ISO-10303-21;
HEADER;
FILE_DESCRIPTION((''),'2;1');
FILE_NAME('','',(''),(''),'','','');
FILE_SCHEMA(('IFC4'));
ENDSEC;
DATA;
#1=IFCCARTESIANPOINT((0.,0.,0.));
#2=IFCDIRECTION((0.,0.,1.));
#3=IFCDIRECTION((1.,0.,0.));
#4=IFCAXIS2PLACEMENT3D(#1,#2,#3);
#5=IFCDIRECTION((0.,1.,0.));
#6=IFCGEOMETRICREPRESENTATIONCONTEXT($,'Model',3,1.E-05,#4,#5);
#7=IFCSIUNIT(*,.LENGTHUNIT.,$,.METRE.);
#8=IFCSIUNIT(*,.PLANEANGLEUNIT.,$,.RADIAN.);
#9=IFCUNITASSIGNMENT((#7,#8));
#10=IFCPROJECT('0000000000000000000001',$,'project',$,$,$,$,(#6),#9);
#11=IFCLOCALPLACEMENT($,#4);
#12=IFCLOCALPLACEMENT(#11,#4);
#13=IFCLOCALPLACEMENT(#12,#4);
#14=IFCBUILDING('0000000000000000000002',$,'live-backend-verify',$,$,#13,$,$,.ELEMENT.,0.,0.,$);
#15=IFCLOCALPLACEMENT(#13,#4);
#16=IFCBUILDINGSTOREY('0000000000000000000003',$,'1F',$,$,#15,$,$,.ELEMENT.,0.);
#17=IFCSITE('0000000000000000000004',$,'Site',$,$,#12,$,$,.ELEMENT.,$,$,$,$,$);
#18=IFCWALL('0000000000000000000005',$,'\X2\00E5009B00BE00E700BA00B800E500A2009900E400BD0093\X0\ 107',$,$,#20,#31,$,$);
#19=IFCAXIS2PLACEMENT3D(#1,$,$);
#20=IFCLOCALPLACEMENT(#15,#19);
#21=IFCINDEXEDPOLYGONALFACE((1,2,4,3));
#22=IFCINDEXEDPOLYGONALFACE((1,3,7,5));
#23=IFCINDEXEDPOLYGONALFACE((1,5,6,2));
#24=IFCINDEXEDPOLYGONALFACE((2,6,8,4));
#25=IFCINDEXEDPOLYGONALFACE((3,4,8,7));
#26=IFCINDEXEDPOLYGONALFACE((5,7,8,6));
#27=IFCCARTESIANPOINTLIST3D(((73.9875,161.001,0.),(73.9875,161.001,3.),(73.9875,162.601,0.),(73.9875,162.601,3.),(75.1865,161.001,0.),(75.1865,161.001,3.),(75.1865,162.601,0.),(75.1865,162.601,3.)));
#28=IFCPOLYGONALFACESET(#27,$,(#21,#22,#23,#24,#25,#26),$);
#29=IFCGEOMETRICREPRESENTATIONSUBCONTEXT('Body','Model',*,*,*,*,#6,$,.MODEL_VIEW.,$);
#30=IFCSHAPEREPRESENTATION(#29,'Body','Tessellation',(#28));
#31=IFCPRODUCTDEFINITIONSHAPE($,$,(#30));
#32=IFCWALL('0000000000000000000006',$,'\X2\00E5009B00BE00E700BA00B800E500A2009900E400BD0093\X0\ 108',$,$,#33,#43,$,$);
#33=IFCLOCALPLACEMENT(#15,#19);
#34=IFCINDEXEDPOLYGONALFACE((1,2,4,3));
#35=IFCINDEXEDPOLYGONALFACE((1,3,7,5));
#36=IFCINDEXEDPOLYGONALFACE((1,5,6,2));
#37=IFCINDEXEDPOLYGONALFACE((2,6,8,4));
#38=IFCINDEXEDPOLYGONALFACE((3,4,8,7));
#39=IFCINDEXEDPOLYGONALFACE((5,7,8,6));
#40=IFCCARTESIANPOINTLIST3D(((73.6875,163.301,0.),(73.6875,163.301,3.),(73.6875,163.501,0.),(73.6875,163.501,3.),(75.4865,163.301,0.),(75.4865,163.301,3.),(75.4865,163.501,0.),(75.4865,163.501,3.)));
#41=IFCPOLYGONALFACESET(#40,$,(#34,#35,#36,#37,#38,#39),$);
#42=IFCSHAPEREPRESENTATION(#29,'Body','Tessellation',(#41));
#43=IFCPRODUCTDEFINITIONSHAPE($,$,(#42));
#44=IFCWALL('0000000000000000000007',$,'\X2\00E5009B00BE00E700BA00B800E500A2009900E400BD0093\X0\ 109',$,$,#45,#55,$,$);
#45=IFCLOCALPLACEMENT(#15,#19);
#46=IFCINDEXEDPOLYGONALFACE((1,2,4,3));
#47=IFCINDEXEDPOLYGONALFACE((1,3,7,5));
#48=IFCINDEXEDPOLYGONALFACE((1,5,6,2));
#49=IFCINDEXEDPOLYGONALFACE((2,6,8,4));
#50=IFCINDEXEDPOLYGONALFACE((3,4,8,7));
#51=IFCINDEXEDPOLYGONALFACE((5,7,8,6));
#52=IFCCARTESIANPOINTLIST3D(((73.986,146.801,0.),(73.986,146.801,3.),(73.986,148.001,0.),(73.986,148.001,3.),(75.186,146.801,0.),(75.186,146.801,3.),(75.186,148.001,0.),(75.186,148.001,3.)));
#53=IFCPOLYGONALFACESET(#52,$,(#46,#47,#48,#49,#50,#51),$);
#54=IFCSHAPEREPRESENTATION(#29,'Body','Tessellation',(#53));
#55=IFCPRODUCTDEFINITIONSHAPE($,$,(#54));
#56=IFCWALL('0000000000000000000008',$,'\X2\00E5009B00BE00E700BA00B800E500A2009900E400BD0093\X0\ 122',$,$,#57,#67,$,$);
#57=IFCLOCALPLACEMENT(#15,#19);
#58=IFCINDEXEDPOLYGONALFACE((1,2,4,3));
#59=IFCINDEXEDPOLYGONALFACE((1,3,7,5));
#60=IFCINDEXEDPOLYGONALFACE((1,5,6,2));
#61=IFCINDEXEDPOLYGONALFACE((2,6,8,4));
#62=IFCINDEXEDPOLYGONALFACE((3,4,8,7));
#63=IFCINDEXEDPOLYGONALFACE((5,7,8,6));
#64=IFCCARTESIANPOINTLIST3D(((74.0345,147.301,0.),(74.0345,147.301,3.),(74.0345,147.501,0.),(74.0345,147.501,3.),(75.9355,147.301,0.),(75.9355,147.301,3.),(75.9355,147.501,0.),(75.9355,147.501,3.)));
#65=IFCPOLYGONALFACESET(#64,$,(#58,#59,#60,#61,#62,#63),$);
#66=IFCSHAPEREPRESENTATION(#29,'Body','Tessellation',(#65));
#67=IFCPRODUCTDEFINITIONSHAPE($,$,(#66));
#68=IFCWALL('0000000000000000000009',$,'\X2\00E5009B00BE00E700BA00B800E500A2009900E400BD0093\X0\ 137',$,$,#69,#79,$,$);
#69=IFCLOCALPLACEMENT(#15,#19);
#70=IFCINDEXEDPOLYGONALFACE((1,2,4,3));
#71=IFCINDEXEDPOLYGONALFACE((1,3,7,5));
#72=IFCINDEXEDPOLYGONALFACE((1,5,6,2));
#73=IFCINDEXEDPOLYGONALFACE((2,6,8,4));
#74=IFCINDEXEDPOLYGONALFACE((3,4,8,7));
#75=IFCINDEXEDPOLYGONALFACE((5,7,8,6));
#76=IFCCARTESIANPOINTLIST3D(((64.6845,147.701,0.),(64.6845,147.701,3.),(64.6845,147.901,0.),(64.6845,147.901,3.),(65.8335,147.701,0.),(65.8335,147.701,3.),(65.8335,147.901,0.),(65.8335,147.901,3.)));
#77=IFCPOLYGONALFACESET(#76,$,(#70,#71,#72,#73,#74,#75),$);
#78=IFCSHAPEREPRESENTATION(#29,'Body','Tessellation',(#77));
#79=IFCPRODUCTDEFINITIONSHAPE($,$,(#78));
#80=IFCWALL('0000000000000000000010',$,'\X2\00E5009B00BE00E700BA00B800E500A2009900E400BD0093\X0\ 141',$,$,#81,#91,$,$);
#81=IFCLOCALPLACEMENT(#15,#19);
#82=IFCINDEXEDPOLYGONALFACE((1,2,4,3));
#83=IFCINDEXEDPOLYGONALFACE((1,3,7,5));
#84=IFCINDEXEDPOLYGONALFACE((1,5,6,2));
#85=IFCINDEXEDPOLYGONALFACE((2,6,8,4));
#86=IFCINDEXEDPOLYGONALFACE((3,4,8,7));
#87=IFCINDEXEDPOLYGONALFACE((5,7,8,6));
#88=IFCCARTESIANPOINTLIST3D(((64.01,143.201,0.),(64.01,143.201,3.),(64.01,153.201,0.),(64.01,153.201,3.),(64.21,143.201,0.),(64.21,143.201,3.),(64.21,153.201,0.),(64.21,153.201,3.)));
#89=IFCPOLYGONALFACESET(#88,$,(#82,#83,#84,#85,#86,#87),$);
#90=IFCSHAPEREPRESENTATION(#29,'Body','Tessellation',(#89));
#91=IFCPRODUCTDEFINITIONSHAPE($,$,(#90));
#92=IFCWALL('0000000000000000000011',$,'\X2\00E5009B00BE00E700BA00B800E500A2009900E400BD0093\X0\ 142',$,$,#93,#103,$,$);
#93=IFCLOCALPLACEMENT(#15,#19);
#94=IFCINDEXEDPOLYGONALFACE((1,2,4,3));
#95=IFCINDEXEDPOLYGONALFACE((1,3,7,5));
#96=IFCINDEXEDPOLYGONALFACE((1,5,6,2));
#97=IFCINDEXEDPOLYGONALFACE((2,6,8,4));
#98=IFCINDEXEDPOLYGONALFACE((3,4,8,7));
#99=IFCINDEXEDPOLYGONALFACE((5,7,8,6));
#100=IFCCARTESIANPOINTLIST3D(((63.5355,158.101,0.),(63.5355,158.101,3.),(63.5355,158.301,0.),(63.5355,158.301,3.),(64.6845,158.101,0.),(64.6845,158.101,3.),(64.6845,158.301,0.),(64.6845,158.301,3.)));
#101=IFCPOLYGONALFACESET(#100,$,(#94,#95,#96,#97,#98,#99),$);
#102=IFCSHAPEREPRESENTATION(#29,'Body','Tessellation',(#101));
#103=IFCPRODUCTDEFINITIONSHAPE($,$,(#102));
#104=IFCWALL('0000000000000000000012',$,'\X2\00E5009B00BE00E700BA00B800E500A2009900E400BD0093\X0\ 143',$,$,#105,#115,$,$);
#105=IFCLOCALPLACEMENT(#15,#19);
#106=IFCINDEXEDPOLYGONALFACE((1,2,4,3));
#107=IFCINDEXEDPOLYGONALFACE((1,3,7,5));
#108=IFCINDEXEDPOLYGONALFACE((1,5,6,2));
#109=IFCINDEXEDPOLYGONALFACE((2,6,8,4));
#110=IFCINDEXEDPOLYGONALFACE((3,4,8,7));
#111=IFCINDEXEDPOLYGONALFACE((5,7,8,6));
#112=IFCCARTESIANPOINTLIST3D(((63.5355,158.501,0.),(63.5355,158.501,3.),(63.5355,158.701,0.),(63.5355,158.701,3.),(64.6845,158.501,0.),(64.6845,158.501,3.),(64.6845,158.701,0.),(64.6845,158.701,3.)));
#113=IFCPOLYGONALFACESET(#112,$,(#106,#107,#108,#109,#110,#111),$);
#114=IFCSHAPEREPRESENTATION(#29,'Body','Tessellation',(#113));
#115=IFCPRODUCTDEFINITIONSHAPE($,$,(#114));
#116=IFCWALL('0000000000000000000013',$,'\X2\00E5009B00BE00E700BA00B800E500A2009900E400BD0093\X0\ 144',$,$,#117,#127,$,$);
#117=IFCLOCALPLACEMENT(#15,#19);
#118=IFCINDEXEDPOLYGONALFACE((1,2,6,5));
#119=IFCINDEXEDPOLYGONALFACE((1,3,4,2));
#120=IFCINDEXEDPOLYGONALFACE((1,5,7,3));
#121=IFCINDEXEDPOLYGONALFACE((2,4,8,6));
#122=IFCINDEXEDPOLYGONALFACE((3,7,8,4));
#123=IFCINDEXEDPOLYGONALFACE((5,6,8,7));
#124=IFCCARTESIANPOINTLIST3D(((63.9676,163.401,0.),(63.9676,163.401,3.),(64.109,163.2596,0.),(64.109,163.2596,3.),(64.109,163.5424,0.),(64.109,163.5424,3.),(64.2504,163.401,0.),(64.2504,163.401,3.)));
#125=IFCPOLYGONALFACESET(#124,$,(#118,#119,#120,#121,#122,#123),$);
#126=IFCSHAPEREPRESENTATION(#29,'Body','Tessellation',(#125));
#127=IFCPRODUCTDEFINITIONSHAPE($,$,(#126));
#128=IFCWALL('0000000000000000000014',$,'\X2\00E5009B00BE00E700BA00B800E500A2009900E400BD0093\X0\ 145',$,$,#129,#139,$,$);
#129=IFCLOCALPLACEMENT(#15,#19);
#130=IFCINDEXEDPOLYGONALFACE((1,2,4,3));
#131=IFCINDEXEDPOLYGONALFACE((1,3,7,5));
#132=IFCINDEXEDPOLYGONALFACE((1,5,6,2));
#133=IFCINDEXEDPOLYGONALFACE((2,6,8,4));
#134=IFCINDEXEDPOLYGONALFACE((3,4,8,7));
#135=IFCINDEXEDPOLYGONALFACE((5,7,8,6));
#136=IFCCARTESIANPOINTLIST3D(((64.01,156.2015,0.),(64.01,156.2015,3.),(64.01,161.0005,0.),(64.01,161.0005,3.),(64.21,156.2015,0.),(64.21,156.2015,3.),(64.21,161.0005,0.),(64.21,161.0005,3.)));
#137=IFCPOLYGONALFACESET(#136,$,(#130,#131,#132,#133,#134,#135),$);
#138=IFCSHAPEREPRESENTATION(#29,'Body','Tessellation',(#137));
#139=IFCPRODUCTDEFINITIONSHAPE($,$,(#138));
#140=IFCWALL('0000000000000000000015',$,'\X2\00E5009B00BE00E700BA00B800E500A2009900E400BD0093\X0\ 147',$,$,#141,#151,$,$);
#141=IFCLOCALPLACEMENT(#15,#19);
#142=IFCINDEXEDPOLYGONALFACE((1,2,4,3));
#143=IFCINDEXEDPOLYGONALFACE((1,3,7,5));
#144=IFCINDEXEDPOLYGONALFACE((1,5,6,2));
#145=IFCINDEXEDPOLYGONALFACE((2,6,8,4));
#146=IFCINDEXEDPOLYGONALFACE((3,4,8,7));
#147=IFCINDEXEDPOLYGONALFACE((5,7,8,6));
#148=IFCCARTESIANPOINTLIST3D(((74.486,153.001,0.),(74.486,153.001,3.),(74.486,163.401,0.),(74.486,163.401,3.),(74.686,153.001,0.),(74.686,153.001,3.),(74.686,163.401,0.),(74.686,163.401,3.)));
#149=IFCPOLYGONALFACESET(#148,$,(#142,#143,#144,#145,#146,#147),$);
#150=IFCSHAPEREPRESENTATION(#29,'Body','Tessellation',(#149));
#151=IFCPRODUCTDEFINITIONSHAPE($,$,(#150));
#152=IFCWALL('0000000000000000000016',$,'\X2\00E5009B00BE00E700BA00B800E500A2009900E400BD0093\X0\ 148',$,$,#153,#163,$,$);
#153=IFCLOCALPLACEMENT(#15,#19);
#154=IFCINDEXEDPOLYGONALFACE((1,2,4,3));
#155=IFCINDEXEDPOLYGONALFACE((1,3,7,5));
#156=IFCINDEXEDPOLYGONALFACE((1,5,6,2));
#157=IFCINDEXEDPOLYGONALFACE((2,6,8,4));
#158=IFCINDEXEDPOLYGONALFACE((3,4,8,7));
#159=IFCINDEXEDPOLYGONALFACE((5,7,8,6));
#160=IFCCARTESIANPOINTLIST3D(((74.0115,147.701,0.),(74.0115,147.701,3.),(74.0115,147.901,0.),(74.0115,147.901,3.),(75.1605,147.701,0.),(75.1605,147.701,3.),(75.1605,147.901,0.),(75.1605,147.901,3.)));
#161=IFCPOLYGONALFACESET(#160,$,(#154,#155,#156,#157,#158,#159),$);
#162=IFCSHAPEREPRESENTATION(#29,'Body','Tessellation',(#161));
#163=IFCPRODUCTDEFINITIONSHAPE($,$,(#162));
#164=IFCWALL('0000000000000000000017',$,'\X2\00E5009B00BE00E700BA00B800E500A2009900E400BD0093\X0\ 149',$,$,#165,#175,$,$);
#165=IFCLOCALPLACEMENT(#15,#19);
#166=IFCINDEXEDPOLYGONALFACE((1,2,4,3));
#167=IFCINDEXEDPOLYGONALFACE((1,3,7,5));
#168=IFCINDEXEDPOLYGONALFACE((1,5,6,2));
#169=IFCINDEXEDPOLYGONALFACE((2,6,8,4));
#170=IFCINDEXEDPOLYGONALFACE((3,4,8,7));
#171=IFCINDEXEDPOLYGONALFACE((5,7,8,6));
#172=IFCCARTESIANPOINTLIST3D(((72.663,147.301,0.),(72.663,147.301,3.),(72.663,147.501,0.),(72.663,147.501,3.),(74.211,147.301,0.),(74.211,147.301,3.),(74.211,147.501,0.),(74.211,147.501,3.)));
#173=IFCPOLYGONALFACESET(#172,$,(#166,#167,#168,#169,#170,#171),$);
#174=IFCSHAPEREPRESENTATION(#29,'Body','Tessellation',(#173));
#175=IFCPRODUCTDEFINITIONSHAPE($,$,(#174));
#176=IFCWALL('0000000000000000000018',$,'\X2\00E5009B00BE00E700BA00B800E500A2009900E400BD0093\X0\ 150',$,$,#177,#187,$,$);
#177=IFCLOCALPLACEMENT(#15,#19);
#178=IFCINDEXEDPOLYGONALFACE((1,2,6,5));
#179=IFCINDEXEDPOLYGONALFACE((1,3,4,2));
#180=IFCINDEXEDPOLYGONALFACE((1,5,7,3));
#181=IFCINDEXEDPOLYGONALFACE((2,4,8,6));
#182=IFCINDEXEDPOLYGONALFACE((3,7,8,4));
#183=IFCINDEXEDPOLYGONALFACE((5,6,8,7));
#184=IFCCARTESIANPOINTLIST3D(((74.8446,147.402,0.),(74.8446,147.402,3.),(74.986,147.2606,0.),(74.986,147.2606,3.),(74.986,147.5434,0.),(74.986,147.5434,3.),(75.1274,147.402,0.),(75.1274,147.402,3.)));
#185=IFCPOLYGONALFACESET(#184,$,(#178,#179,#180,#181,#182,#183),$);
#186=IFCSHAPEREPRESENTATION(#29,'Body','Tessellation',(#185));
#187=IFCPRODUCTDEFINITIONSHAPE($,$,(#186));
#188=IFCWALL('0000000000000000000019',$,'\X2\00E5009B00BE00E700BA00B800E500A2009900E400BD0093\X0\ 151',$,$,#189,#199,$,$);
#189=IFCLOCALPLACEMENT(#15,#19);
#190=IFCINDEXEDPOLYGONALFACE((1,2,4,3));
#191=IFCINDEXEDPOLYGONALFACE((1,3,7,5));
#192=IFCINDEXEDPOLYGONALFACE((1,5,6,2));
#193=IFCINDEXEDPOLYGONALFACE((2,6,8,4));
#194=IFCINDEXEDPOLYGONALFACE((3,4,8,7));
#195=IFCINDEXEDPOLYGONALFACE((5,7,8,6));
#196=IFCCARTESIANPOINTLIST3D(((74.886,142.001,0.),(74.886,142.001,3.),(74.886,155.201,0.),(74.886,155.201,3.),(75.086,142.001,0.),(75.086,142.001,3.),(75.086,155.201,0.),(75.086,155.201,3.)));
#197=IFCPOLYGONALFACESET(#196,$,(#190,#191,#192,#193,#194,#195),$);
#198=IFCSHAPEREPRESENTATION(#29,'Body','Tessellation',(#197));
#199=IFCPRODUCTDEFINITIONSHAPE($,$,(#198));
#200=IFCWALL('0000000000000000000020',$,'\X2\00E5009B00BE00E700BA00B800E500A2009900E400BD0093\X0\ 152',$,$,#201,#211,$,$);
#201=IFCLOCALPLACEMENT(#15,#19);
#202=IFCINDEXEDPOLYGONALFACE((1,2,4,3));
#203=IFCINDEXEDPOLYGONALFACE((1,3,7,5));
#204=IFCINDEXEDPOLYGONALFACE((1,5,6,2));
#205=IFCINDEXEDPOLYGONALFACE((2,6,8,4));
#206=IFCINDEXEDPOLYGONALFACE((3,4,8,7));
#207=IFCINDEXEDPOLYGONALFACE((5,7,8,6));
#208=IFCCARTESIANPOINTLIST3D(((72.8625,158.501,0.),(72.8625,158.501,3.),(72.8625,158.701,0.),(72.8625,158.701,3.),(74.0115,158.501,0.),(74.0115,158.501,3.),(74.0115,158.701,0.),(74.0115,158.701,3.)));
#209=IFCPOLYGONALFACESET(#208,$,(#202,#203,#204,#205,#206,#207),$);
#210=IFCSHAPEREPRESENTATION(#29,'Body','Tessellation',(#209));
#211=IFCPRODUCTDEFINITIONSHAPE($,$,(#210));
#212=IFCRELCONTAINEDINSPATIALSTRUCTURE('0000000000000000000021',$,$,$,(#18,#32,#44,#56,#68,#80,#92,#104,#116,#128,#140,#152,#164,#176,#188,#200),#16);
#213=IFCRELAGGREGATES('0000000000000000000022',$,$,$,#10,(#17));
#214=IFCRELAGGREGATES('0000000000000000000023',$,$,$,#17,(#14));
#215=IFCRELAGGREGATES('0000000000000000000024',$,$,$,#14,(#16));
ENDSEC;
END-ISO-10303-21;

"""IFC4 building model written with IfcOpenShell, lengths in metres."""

from ifc_helpers import new_model, si_unit, direction, frame, frame_2d, origin_with_axes, place, context, subcontext, project, spatial, rectangle, extrude, element, save


model = new_model("IFC4")

# Units and contexts
model_context = context("Model", 3, precision=1e-05, world=origin_with_axes(), true_north=direction((0.0, 1.0, 0.0)))
body_context = subcontext(model_context, "Body", "Model", "MODEL_VIEW")
ifc_project = project(units=[si_unit("LENGTHUNIT", "METRE"), si_unit("PLANEANGLEUNIT", "RADIAN")], contexts=[model_context])

# Site, building, storey
placement = place(None, origin_with_axes())
site_placement = place(placement, origin_with_axes())
site = spatial("IfcSite", under=ifc_project, at=site_placement, Name="Site", CompositionType="ELEMENT")
building_placement = place(site_placement, origin_with_axes())
building = spatial("IfcBuilding", under=site, at=building_placement, Name="live-backend-verify", CompositionType="ELEMENT", ElevationOfRefHeight=0.0, ElevationOfTerrain=0.0)
storey_placement = place(building_placement, origin_with_axes())
storey = spatial("IfcBuildingStorey", under=building, at=storey_placement, Name="1F", CompositionType="ELEMENT", Elevation=0.0)

# Walls
wall_1_placement = place(storey_placement, frame((74.587, 161.801, 0.0), z_axis=(0.0, 0.0, 1.0), x_axis=(1.0, 0.0, 0.0)))
element("IfcWall", 1, at=wall_1_placement, inside=storey, Name="å\u009b¾çº¸å¢\u0099ä½\u0093 107", context=body_context, shape_type="SweptSolid", body=[
    extrude(rectangle(XDim=1.199, YDim=1.6, at=frame_2d((0.0, 0.0), x_axis=(1.0, 0.0, 0.0))), frame((0.0, 0.0, 0.0), z_axis=(0.0, 0.0, 1.0)), (0.0, 0.0, 1.0), 3.0),
])
wall_2_placement = place(storey_placement, frame((74.587, 163.401, 0.0), z_axis=(0.0, 0.0, 1.0), x_axis=(1.0, 0.0, 0.0)))
element("IfcWall", 2, at=wall_2_placement, inside=storey, Name="å\u009b¾çº¸å¢\u0099ä½\u0093 108", context=body_context, shape_type="SweptSolid", body=[
    extrude(rectangle(XDim=1.799, YDim=0.2, at=frame_2d((0.0, 0.0), x_axis=(1.0, 0.0, 0.0))), frame((0.0, 0.0, 0.0), z_axis=(0.0, 0.0, 1.0)), (0.0, 0.0, 1.0), 3.0),
])
wall_3_placement = place(storey_placement, frame((74.586, 147.401, 0.0), z_axis=(0.0, 0.0, 1.0), x_axis=(1.0, 0.0, 0.0)))
element("IfcWall", 3, at=wall_3_placement, inside=storey, Name="å\u009b¾çº¸å¢\u0099ä½\u0093 109", context=body_context, shape_type="SweptSolid", body=[
    extrude(rectangle(XDim=1.2, YDim=1.2, at=frame_2d((0.0, 0.0), x_axis=(1.0, 0.0, 0.0))), frame((0.0, 0.0, 0.0), z_axis=(0.0, 0.0, 1.0)), (0.0, 0.0, 1.0), 3.0),
])
wall_4_placement = place(storey_placement, frame((74.985, 147.401, 0.0), z_axis=(0.0, 0.0, 1.0), x_axis=(1.0, 0.0, 0.0)))
element("IfcWall", 4, at=wall_4_placement, inside=storey, Name="å\u009b¾çº¸å¢\u0099ä½\u0093 122", context=body_context, shape_type="SweptSolid", body=[
    extrude(rectangle(XDim=1.901, YDim=0.2, at=frame_2d((0.0, 0.0), x_axis=(1.0, 0.0, 0.0))), frame((0.0, 0.0, 0.0), z_axis=(0.0, 0.0, 1.0)), (0.0, 0.0, 1.0), 3.0),
])
wall_5_placement = place(storey_placement, frame((65.259, 147.801, 0.0), z_axis=(0.0, 0.0, 1.0), x_axis=(-1.0, 0.0, 0.0)))
element("IfcWall", 5, at=wall_5_placement, inside=storey, Name="å\u009b¾çº¸å¢\u0099ä½\u0093 137", context=body_context, shape_type="SweptSolid", body=[
    extrude(rectangle(XDim=1.149, YDim=0.2, at=frame_2d((0.0, 0.0), x_axis=(1.0, 0.0, 0.0))), frame((0.0, 0.0, 0.0), z_axis=(0.0, 0.0, 1.0)), (0.0, 0.0, 1.0), 3.0),
])
wall_6_placement = place(storey_placement, frame((64.11, 148.201, 0.0), z_axis=(0.0, 0.0, 1.0), x_axis=(0.0, 1.0, 0.0)))
element("IfcWall", 6, at=wall_6_placement, inside=storey, Name="å\u009b¾çº¸å¢\u0099ä½\u0093 141", context=body_context, shape_type="SweptSolid", body=[
    extrude(rectangle(XDim=10.0, YDim=0.2, at=frame_2d((0.0, 0.0), x_axis=(1.0, 0.0, 0.0))), frame((0.0, 0.0, 0.0), z_axis=(0.0, 0.0, 1.0)), (0.0, 0.0, 1.0), 3.0),
])
for number, where, z_axis, x_axis, name in (
    (7, (64.11, 158.201, 0.0), (0.0, 0.0, 1.0), (1.0, 0.0, 0.0), "å\u009b¾çº¸å¢\u0099ä½\u0093 142"),
    (8, (64.11, 158.601, 0.0), (0.0, 0.0, 1.0), (1.0, 0.0, 0.0), "å\u009b¾çº¸å¢\u0099ä½\u0093 143"),
):
    element("IfcWall", number, at=place(storey_placement, frame(where, z_axis=z_axis, x_axis=x_axis)), inside=storey, Name=name, context=body_context, shape_type="SweptSolid", body=[
        extrude(rectangle(XDim=1.149, YDim=0.2, at=frame_2d((0.0, 0.0), x_axis=(1.0, 0.0, 0.0))), frame((0.0, 0.0, 0.0), z_axis=(0.0, 0.0, 1.0)), (0.0, 0.0, 1.0), 3.0),
    ])
wall_7_placement = place(storey_placement, frame((64.109, 163.401, 0.0), z_axis=(0.0, 0.0, 1.0), x_axis=(0.707107, -0.707107, 0.0)))
element("IfcWall", 9, at=wall_7_placement, inside=storey, Name="å\u009b¾çº¸å¢\u0099ä½\u0093 144", context=body_context, shape_type="SweptSolid", body=[
    extrude(rectangle(XDim=0.2, YDim=0.2, at=frame_2d((0.0, 0.0), x_axis=(1.0, 0.0, 0.0))), frame((0.0, 0.0, 0.0), z_axis=(0.0, 0.0, 1.0)), (0.0, 0.0, 1.0), 3.0),
])
wall_8_placement = place(storey_placement, frame((64.11, 158.601, 0.0), z_axis=(0.0, 0.0, 1.0), x_axis=(0.0, 1.0, 0.0)))
element("IfcWall", 10, at=wall_8_placement, inside=storey, Name="å\u009b¾çº¸å¢\u0099ä½\u0093 145", context=body_context, shape_type="SweptSolid", body=[
    extrude(rectangle(XDim=4.799, YDim=0.2, at=frame_2d((0.0, 0.0), x_axis=(1.0, 0.0, 0.0))), frame((0.0, 0.0, 0.0), z_axis=(0.0, 0.0, 1.0)), (0.0, 0.0, 1.0), 3.0),
])
wall_9_placement = place(storey_placement, frame((74.586, 158.201, 0.0), z_axis=(0.0, 0.0, 1.0), x_axis=(0.0, -1.0, 0.0)))
element("IfcWall", 11, at=wall_9_placement, inside=storey, Name="å\u009b¾çº¸å¢\u0099ä½\u0093 147", context=body_context, shape_type="SweptSolid", body=[
    extrude(rectangle(XDim=10.4, YDim=0.2, at=frame_2d((0.0, 0.0), x_axis=(1.0, 0.0, 0.0))), frame((0.0, 0.0, 0.0), z_axis=(0.0, 0.0, 1.0)), (0.0, 0.0, 1.0), 3.0),
])
wall_10_placement = place(storey_placement, frame((74.586, 147.801, 0.0), z_axis=(0.0, 0.0, 1.0), x_axis=(-1.0, 0.0, 0.0)))
element("IfcWall", 12, at=wall_10_placement, inside=storey, Name="å\u009b¾çº¸å¢\u0099ä½\u0093 148", context=body_context, shape_type="SweptSolid", body=[
    extrude(rectangle(XDim=1.149, YDim=0.2, at=frame_2d((0.0, 0.0), x_axis=(1.0, 0.0, 0.0))), frame((0.0, 0.0, 0.0), z_axis=(0.0, 0.0, 1.0)), (0.0, 0.0, 1.0), 3.0),
])
wall_11_placement = place(storey_placement, frame((73.437, 147.401, 0.0), z_axis=(0.0, 0.0, 1.0), x_axis=(1.0, 0.0, 0.0)))
element("IfcWall", 13, at=wall_11_placement, inside=storey, Name="å\u009b¾çº¸å¢\u0099ä½\u0093 149", context=body_context, shape_type="SweptSolid", body=[
    extrude(rectangle(XDim=1.548, YDim=0.2, at=frame_2d((0.0, 0.0), x_axis=(1.0, 0.0, 0.0))), frame((0.0, 0.0, 0.0), z_axis=(0.0, 0.0, 1.0)), (0.0, 0.0, 1.0), 3.0),
])
wall_12_placement = place(storey_placement, frame((74.986, 147.402, 0.0), z_axis=(0.0, 0.0, 1.0), x_axis=(-0.707107, -0.707107, 0.0)))
element("IfcWall", 14, at=wall_12_placement, inside=storey, Name="å\u009b¾çº¸å¢\u0099ä½\u0093 150", context=body_context, shape_type="SweptSolid", body=[
    extrude(rectangle(XDim=0.2, YDim=0.2, at=frame_2d((0.0, 0.0), x_axis=(1.0, 0.0, 0.0))), frame((0.0, 0.0, 0.0), z_axis=(0.0, 0.0, 1.0)), (0.0, 0.0, 1.0), 3.0),
])
wall_13_placement = place(storey_placement, frame((74.986, 148.601, 0.0), z_axis=(0.0, 0.0, 1.0), x_axis=(0.0, 1.0, 0.0)))
element("IfcWall", 15, at=wall_13_placement, inside=storey, Name="å\u009b¾çº¸å¢\u0099ä½\u0093 151", context=body_context, shape_type="SweptSolid", body=[
    extrude(rectangle(XDim=13.2, YDim=0.2, at=frame_2d((0.0, 0.0), x_axis=(1.0, 0.0, 0.0))), frame((0.0, 0.0, 0.0), z_axis=(0.0, 0.0, 1.0)), (0.0, 0.0, 1.0), 3.0),
])
for number, where, z_axis, x_axis, name in (
    (16, (73.437, 158.601, 0.0), (0.0, 0.0, 1.0), (1.0, 0.0, 0.0), "å\u009b¾çº¸å¢\u0099ä½\u0093 152"),
):
    element("IfcWall", number, at=place(storey_placement, frame(where, z_axis=z_axis, x_axis=x_axis)), inside=storey, Name=name, context=body_context, shape_type="SweptSolid", body=[
        extrude(rectangle(XDim=1.149, YDim=0.2, at=frame_2d((0.0, 0.0), x_axis=(1.0, 0.0, 0.0))), frame((0.0, 0.0, 0.0), z_axis=(0.0, 0.0, 1.0)), (0.0, 0.0, 1.0), 3.0),
    ])

save(model, "model.ifc")
